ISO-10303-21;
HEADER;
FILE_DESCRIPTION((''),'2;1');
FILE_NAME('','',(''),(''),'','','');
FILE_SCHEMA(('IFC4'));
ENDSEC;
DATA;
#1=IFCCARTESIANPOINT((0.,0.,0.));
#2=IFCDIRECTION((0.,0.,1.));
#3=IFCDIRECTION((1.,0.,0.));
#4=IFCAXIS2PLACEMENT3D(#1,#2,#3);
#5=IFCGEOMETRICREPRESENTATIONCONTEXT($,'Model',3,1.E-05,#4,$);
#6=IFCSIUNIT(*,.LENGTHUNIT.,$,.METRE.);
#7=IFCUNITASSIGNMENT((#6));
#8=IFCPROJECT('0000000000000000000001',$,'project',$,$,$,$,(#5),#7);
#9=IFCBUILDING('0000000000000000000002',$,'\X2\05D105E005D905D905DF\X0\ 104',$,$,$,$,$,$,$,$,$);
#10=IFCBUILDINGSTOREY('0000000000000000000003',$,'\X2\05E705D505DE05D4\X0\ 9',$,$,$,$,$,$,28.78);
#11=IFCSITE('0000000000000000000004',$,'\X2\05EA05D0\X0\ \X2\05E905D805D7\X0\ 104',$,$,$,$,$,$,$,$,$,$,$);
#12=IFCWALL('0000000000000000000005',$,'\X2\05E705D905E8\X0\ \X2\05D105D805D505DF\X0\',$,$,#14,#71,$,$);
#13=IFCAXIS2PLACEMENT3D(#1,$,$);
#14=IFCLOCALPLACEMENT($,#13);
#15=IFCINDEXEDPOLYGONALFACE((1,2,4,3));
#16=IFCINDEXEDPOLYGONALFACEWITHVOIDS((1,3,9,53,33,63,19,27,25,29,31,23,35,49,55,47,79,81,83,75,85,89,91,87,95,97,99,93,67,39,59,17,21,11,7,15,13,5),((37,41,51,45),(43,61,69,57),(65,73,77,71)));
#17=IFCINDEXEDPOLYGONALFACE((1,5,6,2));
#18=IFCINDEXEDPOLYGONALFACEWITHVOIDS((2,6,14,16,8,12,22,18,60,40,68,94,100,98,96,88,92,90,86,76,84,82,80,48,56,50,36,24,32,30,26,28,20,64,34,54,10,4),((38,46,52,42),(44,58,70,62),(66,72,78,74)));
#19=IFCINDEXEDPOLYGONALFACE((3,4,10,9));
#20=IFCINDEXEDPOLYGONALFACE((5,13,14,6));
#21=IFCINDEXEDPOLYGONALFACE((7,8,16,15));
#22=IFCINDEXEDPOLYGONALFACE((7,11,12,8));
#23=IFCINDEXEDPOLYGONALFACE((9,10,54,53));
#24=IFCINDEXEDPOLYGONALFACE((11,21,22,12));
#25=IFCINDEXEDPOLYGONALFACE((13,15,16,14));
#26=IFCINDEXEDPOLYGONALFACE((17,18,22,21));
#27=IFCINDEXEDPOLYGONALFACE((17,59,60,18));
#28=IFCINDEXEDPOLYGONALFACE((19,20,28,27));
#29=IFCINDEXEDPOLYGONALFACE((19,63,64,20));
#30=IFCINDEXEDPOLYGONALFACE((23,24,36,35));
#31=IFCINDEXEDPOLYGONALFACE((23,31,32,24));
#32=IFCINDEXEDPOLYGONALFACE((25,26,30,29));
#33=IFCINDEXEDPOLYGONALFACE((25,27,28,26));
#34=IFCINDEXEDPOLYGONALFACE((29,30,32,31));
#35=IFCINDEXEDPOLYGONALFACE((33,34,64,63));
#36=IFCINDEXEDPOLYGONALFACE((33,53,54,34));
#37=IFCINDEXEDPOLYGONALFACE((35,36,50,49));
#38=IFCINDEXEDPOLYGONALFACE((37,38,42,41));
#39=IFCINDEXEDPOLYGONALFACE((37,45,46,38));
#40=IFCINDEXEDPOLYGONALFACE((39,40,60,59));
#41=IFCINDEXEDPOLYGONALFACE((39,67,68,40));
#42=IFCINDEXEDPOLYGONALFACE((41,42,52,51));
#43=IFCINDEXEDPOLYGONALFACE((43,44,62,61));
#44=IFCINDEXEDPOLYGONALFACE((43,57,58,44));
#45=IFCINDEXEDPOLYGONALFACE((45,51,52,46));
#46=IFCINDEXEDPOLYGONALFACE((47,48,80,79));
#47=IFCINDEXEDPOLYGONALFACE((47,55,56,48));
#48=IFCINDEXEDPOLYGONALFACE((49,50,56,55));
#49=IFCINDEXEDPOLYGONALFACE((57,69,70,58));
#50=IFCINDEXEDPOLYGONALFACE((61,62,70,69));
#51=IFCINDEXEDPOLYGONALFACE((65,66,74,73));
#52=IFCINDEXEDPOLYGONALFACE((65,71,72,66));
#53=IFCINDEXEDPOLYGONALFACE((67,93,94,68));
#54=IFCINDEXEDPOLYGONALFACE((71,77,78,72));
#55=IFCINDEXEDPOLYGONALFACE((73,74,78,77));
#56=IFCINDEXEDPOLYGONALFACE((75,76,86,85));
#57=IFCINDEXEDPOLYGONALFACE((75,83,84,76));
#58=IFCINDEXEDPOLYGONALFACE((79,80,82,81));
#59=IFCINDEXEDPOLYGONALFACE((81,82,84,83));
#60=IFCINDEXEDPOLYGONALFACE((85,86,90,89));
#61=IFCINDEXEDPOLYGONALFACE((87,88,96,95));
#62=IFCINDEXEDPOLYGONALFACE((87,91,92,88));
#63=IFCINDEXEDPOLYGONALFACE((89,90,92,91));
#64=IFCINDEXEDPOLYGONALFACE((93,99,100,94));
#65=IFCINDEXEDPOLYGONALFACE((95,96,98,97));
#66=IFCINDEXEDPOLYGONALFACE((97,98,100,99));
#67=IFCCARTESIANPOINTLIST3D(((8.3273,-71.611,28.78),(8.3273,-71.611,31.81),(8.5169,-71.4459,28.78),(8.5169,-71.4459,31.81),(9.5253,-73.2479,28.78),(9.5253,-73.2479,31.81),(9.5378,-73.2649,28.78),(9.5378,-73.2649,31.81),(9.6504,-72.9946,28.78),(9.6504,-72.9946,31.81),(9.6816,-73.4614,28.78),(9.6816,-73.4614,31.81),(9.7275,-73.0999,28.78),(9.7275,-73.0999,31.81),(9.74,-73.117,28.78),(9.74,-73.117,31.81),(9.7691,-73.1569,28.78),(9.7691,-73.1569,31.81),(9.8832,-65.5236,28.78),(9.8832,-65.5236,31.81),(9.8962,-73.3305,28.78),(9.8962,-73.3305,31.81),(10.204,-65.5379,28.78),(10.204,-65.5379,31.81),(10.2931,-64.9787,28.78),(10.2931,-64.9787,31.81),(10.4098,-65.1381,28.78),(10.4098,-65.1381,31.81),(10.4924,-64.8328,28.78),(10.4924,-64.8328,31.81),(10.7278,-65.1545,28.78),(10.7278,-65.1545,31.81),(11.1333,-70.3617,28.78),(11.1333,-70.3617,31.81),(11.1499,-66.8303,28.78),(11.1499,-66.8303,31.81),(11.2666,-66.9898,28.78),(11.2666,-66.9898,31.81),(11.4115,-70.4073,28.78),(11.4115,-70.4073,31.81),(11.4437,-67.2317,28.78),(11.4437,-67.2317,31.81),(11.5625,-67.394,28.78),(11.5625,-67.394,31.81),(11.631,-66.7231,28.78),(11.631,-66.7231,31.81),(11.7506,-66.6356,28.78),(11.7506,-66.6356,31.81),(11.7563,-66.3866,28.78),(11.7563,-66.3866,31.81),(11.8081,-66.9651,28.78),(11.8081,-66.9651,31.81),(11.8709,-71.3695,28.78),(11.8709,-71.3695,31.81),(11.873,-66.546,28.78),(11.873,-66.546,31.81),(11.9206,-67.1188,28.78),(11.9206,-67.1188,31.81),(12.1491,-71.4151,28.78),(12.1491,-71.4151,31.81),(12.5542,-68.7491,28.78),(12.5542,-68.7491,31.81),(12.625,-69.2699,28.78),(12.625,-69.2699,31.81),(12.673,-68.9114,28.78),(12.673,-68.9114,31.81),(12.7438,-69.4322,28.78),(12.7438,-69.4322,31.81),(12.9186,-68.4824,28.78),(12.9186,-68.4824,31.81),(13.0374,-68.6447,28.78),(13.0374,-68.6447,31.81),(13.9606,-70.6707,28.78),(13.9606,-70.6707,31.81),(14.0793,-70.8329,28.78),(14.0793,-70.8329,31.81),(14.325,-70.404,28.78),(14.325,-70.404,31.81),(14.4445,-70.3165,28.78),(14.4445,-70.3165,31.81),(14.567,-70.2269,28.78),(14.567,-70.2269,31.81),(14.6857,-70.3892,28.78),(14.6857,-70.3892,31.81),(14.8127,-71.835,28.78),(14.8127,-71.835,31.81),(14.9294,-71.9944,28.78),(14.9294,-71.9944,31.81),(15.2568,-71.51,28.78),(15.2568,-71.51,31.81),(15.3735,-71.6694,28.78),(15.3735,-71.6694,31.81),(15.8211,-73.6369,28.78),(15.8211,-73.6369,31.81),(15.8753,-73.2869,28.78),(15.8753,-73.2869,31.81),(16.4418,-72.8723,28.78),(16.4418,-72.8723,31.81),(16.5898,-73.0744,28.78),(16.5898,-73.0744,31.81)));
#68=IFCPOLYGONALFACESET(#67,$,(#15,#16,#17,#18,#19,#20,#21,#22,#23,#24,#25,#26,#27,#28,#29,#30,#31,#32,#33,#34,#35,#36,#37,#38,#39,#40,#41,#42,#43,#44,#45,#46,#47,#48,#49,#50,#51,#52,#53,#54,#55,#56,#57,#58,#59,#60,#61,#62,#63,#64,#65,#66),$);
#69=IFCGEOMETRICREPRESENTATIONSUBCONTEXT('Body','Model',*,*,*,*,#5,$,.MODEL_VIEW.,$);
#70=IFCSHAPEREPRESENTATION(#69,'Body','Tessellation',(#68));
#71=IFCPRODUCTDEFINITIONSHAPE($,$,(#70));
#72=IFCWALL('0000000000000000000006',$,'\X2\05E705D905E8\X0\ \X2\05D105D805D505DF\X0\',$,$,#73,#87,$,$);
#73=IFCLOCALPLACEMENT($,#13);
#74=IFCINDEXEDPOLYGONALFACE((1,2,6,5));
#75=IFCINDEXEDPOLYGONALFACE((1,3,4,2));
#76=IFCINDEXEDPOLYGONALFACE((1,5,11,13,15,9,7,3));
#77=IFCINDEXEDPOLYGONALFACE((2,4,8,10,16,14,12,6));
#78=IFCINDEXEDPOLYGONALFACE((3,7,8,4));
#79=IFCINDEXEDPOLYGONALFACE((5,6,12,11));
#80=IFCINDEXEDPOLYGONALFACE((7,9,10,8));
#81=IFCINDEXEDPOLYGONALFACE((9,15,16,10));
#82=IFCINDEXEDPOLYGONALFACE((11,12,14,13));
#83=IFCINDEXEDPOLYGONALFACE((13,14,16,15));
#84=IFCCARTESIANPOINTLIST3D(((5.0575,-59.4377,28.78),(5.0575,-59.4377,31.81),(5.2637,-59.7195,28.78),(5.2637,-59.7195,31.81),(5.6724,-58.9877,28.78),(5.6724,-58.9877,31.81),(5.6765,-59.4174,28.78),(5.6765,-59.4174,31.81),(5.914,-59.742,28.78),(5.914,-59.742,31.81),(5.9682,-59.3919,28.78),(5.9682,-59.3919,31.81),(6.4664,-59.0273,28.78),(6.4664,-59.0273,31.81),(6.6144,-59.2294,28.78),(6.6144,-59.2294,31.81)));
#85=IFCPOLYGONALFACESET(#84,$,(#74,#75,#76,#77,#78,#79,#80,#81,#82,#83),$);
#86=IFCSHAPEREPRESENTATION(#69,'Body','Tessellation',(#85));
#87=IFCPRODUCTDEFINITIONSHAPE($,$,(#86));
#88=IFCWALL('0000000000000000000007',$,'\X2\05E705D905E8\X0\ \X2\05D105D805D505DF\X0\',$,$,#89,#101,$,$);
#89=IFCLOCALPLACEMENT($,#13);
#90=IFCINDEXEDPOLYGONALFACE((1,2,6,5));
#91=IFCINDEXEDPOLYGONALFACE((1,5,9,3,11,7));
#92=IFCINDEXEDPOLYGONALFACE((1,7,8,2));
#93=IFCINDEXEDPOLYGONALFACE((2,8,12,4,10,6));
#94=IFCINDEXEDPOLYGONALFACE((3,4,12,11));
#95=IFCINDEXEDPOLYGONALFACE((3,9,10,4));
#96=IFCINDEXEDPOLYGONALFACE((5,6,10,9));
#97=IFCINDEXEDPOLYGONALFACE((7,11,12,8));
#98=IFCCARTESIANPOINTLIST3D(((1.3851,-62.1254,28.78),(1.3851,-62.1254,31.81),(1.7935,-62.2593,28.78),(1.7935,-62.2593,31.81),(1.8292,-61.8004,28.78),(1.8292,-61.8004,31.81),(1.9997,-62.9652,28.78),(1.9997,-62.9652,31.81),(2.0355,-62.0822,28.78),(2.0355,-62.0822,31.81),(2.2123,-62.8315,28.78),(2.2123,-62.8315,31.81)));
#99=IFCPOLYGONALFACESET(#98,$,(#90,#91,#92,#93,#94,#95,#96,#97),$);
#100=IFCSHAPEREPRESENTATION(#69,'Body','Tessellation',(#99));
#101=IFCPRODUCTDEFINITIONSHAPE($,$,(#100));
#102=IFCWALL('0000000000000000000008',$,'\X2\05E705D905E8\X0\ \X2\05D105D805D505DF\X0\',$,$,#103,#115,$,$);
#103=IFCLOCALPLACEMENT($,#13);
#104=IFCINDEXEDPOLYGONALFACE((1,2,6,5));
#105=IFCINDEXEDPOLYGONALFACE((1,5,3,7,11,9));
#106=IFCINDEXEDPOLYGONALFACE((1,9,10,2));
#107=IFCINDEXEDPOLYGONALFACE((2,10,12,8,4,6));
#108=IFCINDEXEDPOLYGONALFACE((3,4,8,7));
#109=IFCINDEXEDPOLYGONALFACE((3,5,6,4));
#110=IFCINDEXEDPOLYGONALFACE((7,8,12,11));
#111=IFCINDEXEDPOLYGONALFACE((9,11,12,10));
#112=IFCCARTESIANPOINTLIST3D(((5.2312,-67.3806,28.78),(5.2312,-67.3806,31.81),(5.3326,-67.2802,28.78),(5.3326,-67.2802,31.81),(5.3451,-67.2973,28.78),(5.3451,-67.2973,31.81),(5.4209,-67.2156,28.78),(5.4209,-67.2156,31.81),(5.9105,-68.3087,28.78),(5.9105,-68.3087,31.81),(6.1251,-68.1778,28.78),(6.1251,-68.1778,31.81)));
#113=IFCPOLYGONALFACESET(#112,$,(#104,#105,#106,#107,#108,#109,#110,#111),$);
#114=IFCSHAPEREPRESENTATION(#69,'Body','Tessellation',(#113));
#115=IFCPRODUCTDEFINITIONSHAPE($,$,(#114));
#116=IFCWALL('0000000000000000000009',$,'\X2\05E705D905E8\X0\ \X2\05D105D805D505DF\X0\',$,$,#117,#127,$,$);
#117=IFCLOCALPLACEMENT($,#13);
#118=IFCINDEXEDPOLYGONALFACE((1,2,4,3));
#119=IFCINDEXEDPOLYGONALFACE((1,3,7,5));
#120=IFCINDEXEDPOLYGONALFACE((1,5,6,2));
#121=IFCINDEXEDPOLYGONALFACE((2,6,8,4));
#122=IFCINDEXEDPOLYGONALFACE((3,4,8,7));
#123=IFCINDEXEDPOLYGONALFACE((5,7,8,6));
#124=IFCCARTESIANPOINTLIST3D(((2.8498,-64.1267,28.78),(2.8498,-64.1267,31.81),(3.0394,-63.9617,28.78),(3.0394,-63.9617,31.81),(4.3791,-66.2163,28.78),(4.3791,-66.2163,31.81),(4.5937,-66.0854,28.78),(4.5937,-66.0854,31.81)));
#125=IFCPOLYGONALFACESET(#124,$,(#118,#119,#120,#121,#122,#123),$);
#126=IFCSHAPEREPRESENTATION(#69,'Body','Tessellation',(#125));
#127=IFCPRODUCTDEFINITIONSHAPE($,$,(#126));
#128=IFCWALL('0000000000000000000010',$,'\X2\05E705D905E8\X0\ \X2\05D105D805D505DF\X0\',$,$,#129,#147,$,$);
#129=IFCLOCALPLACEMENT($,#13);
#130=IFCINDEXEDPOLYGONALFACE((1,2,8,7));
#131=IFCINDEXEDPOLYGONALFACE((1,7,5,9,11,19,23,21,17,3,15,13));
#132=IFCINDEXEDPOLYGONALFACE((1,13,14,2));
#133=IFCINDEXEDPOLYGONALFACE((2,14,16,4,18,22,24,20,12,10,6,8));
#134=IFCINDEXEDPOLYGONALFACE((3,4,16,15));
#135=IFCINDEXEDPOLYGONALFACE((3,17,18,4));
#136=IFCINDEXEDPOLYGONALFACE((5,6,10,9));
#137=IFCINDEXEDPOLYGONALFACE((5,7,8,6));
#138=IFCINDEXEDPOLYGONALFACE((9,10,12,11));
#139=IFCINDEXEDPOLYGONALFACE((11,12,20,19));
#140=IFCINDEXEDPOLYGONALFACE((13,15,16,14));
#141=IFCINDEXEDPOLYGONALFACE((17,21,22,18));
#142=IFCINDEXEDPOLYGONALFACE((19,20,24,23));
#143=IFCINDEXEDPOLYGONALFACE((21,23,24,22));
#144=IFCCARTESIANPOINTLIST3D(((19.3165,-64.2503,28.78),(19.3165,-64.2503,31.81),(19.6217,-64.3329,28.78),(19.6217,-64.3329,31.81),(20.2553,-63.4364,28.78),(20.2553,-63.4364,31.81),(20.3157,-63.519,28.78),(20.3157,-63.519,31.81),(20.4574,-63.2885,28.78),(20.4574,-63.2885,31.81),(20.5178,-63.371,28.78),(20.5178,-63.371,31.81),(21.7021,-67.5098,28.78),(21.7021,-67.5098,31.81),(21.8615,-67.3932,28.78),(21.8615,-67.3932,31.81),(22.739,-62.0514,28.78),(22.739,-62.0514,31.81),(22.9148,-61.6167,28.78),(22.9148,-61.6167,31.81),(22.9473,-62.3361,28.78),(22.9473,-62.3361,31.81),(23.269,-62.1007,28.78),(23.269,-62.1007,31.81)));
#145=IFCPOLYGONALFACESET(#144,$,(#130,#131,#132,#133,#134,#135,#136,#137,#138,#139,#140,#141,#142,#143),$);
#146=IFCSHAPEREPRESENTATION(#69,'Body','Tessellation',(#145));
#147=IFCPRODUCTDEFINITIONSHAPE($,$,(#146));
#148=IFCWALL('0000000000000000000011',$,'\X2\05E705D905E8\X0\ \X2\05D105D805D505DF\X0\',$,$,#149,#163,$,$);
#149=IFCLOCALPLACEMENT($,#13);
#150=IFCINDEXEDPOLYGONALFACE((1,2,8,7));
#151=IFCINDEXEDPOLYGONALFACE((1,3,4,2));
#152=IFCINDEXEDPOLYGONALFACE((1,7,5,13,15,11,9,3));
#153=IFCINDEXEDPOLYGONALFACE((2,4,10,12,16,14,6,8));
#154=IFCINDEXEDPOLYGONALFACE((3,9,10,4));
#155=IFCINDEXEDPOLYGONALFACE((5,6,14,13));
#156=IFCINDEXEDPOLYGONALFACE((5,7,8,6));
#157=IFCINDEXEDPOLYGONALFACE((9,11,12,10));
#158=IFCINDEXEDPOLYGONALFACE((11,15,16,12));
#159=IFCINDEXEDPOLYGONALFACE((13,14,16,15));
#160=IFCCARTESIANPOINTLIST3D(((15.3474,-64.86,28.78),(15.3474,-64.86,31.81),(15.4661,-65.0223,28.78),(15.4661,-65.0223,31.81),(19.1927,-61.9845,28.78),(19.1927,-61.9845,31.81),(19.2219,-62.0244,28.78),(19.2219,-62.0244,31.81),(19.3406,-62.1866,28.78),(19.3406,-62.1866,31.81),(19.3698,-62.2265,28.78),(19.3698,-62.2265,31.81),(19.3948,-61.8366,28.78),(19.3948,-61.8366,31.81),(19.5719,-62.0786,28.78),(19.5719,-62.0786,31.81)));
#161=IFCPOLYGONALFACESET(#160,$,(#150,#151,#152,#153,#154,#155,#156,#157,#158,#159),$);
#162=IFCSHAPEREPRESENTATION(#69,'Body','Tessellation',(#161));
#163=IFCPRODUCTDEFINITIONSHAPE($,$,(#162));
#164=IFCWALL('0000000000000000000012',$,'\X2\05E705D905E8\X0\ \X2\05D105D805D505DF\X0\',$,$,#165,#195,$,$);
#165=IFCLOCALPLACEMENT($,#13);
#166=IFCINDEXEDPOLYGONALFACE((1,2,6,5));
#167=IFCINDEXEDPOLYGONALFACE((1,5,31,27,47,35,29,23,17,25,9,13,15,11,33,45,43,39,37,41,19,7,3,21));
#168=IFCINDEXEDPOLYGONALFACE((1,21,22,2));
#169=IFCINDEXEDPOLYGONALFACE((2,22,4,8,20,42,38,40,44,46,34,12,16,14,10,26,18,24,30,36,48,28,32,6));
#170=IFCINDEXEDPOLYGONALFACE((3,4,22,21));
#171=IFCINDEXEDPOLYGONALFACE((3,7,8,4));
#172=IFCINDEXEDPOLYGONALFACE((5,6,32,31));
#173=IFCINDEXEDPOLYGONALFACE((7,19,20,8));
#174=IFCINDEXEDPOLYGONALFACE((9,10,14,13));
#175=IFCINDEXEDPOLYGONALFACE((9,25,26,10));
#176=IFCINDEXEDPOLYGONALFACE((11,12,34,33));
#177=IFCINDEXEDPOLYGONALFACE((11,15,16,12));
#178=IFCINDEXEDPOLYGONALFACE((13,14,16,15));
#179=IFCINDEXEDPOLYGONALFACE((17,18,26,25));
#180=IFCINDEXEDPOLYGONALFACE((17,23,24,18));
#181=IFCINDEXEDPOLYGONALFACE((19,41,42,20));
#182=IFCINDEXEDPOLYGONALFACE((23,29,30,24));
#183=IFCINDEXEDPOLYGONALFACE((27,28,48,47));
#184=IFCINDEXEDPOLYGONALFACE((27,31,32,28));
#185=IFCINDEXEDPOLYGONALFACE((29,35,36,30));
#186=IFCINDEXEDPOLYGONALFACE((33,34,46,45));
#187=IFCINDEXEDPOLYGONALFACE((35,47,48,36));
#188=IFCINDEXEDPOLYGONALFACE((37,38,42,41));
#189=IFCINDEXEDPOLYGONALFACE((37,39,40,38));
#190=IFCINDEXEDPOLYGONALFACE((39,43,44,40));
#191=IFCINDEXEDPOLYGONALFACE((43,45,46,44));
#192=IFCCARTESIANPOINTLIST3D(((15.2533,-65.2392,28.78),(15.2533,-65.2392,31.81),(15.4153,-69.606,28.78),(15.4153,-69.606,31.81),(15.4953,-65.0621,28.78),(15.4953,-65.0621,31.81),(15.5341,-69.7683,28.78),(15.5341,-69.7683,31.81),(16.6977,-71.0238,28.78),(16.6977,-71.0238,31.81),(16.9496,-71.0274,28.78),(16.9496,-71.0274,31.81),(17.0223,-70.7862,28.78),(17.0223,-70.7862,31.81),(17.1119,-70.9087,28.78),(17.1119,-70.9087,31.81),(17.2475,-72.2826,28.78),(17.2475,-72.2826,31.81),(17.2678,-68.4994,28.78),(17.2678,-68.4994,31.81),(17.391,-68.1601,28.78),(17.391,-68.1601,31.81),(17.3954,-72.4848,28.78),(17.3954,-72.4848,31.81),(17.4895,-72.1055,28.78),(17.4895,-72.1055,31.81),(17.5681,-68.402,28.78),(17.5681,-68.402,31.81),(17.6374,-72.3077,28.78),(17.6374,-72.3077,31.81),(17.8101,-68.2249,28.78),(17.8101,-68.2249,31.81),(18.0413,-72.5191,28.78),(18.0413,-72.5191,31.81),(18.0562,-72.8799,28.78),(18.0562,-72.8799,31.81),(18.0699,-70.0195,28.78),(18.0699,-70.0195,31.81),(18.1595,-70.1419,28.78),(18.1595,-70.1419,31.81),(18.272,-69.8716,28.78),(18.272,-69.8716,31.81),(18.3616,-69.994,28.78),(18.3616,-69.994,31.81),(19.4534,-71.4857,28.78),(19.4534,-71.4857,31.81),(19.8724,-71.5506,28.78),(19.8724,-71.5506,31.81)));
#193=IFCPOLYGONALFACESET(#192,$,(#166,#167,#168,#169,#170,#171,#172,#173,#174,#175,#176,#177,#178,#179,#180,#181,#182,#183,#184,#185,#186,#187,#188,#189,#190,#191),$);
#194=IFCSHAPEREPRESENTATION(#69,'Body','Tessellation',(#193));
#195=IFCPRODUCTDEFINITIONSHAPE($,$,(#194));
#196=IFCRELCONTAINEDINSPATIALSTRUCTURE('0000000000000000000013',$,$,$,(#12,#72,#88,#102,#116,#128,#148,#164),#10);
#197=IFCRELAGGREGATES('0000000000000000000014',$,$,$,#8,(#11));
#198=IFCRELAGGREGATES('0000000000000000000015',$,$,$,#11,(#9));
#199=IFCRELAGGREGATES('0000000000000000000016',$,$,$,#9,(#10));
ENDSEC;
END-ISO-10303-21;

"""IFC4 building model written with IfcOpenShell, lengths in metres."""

from ifc_helpers import new_model, si_unit, frame, origin_with_axes, context, subcontext, project, spatial, polyline, outline, extrude, element, save


model = new_model("IFC4")

# Units and contexts
model_context = context("Model", 3, precision=1e-05, world=origin_with_axes())
body_context = subcontext(model_context, "Body", "Model", "MODEL_VIEW")
ifc_project = project(units=[si_unit("LENGTHUNIT", "METRE")], contexts=[model_context])

# Site, building, storey
site = spatial("IfcSite", under=ifc_project, Name="תא שטח 104")
building = spatial("IfcBuilding", under=site, Name="בניין 104")
storey = spatial("IfcBuildingStorey", under=building, Name="קומה 9", Elevation=28.78)

# Walls
element("IfcWall", 1, inside=storey, Name="קיר בטון", context=body_context, shape_type="SweptSolid", body=[
    extrude(outline(polyline([(10.4098, -65.1381), (9.8832, -65.5236), (12.625, -69.2699), (11.1333, -70.3617), (11.8709, -71.3695), (9.6504, -72.9946), (8.5169, -71.4459), (8.3273, -71.611), (9.5253, -73.2479), (9.7275, -73.0999), (9.74, -73.117), (9.5378, -73.2649), (9.6816, -73.4614), (9.8962, -73.3305), (9.7691, -73.1569), (12.1491, -71.4151), (11.4115, -70.4073), (12.7438, -69.4322), (15.8211, -73.6369), (16.5898, -73.0744), (16.4418, -72.8723), (15.8753, -73.2869), (14.9294, -71.9944), (15.3735, -71.6694), (15.2568, -71.51), (14.8127, -71.835), (14.0793, -70.8329), (14.6857, -70.3892), (14.567, -70.2269), (14.4445, -70.3165), (11.7506, -66.6356), (11.873, -66.546), (11.7563, -66.3866), (11.1499, -66.8303), (10.204, -65.5379), (10.7278, -65.1545), (10.4924, -64.8328), (10.2931, -64.9787), (10.4098, -65.1381)]), holes=[polyline([(11.4437, -67.2317), (11.2666, -66.9898), (11.631, -66.7231), (11.8081, -66.9651), (11.4437, -67.2317)]), polyline([(11.5625, -67.394), (11.9206, -67.1188), (12.9186, -68.4824), (12.5542, -68.7491), (11.4437, -67.2317), (11.5625, -67.394)]), polyline([(13.0374, -68.6447), (14.325, -70.404), (13.9606, -70.6707), (12.673, -68.9114), (13.0374, -68.6447)])]), frame((0.0, 0.0, 28.78)), (0.0, 0.0, 1.0), 3.03),
])
element("IfcWall", 2, inside=storey, Name="קיר בטון", context=body_context, shape_type="SweptSolid", body=[
    extrude(outline(polyline([(6.4664, -59.0273), (5.9682, -59.3919), (5.6724, -58.9877), (5.0575, -59.4377), (5.2637, -59.7195), (5.6765, -59.4174), (5.914, -59.742), (6.6144, -59.2294), (6.4664, -59.0273)])), frame((0.0, 0.0, 28.78)), (0.0, 0.0, 1.0), 3.03),
])
element("IfcWall", 3, inside=storey, Name="קיר בטון", context=body_context, shape_type="SweptSolid", body=[
    extrude(outline(polyline([(1.3851, -62.1254), (1.9997, -62.9652), (2.2123, -62.8315), (1.7935, -62.2593), (2.0355, -62.0822), (1.8292, -61.8004), (1.3851, -62.1254)])), frame((0.0, 0.0, 28.78)), (0.0, 0.0, 1.0), 3.03),
])
element("IfcWall", 4, inside=storey, Name="קיר בטון", context=body_context, shape_type="SweptSolid", body=[
    extrude(outline(polyline([(5.3326, -67.2802), (5.3451, -67.2973), (5.2312, -67.3806), (5.9105, -68.3087), (6.1251, -68.1778), (5.4209, -67.2156), (5.3326, -67.2802)])), frame((0.0, 0.0, 28.78)), (0.0, 0.0, 1.0), 3.03),
])
element("IfcWall", 5, inside=storey, Name="קיר בטון", context=body_context, shape_type="SweptSolid", body=[
    extrude(outline(polyline([(2.8498, -64.1267), (4.3791, -66.2163), (4.5937, -66.0854), (3.0394, -63.9617), (2.8498, -64.1267)])), frame((0.0, 0.0, 28.78)), (0.0, 0.0, 1.0), 3.03),
])
element("IfcWall", 6, inside=storey, Name="קיר בטון", context=body_context, shape_type="SweptSolid", body=[
    extrude(outline(polyline([(20.4574, -63.2885), (20.2553, -63.4364), (20.3157, -63.519), (19.3165, -64.2503), (21.7021, -67.5098), (21.8615, -67.3932), (19.6217, -64.3329), (22.739, -62.0514), (22.9473, -62.3361), (23.269, -62.1007), (22.9148, -61.6167), (20.5178, -63.371), (20.4574, -63.2885)])), frame((0.0, 0.0, 28.78)), (0.0, 0.0, 1.0), 3.03),
])
element("IfcWall", 7, inside=storey, Name="קיר בטון", context=body_context, shape_type="SweptSolid", body=[
    extrude(outline(polyline([(19.5719, -62.0786), (19.3948, -61.8366), (19.1927, -61.9845), (19.2219, -62.0244), (15.3474, -64.86), (15.4661, -65.0223), (19.3406, -62.1866), (19.3698, -62.2265), (19.5719, -62.0786)])), frame((0.0, 0.0, 28.78)), (0.0, 0.0, 1.0), 3.03),
])
element("IfcWall", 8, inside=storey, Name="קיר בטון", context=body_context, shape_type="SweptSolid", body=[
    extrude(outline(polyline([(15.2533, -65.2392), (17.391, -68.1601), (15.4153, -69.606), (15.5341, -69.7683), (17.2678, -68.4994), (18.272, -69.8716), (18.0699, -70.0195), (18.1595, -70.1419), (18.3616, -69.994), (19.4534, -71.4857), (18.0413, -72.5191), (16.9496, -71.0274), (17.1119, -70.9087), (17.0223, -70.7862), (16.6977, -71.0238), (17.4895, -72.1055), (17.2475, -72.2826), (17.3954, -72.4848), (17.6374, -72.3077), (18.0562, -72.8799), (19.8724, -71.5506), (17.5681, -68.402), (17.8101, -68.2249), (15.4953, -65.0621), (15.2533, -65.2392), (15.2533, -65.2392)])), frame((0.0, 0.0, 28.78)), (0.0, 0.0, 1.0), 3.03),
])

save(model, "model.ifc")
